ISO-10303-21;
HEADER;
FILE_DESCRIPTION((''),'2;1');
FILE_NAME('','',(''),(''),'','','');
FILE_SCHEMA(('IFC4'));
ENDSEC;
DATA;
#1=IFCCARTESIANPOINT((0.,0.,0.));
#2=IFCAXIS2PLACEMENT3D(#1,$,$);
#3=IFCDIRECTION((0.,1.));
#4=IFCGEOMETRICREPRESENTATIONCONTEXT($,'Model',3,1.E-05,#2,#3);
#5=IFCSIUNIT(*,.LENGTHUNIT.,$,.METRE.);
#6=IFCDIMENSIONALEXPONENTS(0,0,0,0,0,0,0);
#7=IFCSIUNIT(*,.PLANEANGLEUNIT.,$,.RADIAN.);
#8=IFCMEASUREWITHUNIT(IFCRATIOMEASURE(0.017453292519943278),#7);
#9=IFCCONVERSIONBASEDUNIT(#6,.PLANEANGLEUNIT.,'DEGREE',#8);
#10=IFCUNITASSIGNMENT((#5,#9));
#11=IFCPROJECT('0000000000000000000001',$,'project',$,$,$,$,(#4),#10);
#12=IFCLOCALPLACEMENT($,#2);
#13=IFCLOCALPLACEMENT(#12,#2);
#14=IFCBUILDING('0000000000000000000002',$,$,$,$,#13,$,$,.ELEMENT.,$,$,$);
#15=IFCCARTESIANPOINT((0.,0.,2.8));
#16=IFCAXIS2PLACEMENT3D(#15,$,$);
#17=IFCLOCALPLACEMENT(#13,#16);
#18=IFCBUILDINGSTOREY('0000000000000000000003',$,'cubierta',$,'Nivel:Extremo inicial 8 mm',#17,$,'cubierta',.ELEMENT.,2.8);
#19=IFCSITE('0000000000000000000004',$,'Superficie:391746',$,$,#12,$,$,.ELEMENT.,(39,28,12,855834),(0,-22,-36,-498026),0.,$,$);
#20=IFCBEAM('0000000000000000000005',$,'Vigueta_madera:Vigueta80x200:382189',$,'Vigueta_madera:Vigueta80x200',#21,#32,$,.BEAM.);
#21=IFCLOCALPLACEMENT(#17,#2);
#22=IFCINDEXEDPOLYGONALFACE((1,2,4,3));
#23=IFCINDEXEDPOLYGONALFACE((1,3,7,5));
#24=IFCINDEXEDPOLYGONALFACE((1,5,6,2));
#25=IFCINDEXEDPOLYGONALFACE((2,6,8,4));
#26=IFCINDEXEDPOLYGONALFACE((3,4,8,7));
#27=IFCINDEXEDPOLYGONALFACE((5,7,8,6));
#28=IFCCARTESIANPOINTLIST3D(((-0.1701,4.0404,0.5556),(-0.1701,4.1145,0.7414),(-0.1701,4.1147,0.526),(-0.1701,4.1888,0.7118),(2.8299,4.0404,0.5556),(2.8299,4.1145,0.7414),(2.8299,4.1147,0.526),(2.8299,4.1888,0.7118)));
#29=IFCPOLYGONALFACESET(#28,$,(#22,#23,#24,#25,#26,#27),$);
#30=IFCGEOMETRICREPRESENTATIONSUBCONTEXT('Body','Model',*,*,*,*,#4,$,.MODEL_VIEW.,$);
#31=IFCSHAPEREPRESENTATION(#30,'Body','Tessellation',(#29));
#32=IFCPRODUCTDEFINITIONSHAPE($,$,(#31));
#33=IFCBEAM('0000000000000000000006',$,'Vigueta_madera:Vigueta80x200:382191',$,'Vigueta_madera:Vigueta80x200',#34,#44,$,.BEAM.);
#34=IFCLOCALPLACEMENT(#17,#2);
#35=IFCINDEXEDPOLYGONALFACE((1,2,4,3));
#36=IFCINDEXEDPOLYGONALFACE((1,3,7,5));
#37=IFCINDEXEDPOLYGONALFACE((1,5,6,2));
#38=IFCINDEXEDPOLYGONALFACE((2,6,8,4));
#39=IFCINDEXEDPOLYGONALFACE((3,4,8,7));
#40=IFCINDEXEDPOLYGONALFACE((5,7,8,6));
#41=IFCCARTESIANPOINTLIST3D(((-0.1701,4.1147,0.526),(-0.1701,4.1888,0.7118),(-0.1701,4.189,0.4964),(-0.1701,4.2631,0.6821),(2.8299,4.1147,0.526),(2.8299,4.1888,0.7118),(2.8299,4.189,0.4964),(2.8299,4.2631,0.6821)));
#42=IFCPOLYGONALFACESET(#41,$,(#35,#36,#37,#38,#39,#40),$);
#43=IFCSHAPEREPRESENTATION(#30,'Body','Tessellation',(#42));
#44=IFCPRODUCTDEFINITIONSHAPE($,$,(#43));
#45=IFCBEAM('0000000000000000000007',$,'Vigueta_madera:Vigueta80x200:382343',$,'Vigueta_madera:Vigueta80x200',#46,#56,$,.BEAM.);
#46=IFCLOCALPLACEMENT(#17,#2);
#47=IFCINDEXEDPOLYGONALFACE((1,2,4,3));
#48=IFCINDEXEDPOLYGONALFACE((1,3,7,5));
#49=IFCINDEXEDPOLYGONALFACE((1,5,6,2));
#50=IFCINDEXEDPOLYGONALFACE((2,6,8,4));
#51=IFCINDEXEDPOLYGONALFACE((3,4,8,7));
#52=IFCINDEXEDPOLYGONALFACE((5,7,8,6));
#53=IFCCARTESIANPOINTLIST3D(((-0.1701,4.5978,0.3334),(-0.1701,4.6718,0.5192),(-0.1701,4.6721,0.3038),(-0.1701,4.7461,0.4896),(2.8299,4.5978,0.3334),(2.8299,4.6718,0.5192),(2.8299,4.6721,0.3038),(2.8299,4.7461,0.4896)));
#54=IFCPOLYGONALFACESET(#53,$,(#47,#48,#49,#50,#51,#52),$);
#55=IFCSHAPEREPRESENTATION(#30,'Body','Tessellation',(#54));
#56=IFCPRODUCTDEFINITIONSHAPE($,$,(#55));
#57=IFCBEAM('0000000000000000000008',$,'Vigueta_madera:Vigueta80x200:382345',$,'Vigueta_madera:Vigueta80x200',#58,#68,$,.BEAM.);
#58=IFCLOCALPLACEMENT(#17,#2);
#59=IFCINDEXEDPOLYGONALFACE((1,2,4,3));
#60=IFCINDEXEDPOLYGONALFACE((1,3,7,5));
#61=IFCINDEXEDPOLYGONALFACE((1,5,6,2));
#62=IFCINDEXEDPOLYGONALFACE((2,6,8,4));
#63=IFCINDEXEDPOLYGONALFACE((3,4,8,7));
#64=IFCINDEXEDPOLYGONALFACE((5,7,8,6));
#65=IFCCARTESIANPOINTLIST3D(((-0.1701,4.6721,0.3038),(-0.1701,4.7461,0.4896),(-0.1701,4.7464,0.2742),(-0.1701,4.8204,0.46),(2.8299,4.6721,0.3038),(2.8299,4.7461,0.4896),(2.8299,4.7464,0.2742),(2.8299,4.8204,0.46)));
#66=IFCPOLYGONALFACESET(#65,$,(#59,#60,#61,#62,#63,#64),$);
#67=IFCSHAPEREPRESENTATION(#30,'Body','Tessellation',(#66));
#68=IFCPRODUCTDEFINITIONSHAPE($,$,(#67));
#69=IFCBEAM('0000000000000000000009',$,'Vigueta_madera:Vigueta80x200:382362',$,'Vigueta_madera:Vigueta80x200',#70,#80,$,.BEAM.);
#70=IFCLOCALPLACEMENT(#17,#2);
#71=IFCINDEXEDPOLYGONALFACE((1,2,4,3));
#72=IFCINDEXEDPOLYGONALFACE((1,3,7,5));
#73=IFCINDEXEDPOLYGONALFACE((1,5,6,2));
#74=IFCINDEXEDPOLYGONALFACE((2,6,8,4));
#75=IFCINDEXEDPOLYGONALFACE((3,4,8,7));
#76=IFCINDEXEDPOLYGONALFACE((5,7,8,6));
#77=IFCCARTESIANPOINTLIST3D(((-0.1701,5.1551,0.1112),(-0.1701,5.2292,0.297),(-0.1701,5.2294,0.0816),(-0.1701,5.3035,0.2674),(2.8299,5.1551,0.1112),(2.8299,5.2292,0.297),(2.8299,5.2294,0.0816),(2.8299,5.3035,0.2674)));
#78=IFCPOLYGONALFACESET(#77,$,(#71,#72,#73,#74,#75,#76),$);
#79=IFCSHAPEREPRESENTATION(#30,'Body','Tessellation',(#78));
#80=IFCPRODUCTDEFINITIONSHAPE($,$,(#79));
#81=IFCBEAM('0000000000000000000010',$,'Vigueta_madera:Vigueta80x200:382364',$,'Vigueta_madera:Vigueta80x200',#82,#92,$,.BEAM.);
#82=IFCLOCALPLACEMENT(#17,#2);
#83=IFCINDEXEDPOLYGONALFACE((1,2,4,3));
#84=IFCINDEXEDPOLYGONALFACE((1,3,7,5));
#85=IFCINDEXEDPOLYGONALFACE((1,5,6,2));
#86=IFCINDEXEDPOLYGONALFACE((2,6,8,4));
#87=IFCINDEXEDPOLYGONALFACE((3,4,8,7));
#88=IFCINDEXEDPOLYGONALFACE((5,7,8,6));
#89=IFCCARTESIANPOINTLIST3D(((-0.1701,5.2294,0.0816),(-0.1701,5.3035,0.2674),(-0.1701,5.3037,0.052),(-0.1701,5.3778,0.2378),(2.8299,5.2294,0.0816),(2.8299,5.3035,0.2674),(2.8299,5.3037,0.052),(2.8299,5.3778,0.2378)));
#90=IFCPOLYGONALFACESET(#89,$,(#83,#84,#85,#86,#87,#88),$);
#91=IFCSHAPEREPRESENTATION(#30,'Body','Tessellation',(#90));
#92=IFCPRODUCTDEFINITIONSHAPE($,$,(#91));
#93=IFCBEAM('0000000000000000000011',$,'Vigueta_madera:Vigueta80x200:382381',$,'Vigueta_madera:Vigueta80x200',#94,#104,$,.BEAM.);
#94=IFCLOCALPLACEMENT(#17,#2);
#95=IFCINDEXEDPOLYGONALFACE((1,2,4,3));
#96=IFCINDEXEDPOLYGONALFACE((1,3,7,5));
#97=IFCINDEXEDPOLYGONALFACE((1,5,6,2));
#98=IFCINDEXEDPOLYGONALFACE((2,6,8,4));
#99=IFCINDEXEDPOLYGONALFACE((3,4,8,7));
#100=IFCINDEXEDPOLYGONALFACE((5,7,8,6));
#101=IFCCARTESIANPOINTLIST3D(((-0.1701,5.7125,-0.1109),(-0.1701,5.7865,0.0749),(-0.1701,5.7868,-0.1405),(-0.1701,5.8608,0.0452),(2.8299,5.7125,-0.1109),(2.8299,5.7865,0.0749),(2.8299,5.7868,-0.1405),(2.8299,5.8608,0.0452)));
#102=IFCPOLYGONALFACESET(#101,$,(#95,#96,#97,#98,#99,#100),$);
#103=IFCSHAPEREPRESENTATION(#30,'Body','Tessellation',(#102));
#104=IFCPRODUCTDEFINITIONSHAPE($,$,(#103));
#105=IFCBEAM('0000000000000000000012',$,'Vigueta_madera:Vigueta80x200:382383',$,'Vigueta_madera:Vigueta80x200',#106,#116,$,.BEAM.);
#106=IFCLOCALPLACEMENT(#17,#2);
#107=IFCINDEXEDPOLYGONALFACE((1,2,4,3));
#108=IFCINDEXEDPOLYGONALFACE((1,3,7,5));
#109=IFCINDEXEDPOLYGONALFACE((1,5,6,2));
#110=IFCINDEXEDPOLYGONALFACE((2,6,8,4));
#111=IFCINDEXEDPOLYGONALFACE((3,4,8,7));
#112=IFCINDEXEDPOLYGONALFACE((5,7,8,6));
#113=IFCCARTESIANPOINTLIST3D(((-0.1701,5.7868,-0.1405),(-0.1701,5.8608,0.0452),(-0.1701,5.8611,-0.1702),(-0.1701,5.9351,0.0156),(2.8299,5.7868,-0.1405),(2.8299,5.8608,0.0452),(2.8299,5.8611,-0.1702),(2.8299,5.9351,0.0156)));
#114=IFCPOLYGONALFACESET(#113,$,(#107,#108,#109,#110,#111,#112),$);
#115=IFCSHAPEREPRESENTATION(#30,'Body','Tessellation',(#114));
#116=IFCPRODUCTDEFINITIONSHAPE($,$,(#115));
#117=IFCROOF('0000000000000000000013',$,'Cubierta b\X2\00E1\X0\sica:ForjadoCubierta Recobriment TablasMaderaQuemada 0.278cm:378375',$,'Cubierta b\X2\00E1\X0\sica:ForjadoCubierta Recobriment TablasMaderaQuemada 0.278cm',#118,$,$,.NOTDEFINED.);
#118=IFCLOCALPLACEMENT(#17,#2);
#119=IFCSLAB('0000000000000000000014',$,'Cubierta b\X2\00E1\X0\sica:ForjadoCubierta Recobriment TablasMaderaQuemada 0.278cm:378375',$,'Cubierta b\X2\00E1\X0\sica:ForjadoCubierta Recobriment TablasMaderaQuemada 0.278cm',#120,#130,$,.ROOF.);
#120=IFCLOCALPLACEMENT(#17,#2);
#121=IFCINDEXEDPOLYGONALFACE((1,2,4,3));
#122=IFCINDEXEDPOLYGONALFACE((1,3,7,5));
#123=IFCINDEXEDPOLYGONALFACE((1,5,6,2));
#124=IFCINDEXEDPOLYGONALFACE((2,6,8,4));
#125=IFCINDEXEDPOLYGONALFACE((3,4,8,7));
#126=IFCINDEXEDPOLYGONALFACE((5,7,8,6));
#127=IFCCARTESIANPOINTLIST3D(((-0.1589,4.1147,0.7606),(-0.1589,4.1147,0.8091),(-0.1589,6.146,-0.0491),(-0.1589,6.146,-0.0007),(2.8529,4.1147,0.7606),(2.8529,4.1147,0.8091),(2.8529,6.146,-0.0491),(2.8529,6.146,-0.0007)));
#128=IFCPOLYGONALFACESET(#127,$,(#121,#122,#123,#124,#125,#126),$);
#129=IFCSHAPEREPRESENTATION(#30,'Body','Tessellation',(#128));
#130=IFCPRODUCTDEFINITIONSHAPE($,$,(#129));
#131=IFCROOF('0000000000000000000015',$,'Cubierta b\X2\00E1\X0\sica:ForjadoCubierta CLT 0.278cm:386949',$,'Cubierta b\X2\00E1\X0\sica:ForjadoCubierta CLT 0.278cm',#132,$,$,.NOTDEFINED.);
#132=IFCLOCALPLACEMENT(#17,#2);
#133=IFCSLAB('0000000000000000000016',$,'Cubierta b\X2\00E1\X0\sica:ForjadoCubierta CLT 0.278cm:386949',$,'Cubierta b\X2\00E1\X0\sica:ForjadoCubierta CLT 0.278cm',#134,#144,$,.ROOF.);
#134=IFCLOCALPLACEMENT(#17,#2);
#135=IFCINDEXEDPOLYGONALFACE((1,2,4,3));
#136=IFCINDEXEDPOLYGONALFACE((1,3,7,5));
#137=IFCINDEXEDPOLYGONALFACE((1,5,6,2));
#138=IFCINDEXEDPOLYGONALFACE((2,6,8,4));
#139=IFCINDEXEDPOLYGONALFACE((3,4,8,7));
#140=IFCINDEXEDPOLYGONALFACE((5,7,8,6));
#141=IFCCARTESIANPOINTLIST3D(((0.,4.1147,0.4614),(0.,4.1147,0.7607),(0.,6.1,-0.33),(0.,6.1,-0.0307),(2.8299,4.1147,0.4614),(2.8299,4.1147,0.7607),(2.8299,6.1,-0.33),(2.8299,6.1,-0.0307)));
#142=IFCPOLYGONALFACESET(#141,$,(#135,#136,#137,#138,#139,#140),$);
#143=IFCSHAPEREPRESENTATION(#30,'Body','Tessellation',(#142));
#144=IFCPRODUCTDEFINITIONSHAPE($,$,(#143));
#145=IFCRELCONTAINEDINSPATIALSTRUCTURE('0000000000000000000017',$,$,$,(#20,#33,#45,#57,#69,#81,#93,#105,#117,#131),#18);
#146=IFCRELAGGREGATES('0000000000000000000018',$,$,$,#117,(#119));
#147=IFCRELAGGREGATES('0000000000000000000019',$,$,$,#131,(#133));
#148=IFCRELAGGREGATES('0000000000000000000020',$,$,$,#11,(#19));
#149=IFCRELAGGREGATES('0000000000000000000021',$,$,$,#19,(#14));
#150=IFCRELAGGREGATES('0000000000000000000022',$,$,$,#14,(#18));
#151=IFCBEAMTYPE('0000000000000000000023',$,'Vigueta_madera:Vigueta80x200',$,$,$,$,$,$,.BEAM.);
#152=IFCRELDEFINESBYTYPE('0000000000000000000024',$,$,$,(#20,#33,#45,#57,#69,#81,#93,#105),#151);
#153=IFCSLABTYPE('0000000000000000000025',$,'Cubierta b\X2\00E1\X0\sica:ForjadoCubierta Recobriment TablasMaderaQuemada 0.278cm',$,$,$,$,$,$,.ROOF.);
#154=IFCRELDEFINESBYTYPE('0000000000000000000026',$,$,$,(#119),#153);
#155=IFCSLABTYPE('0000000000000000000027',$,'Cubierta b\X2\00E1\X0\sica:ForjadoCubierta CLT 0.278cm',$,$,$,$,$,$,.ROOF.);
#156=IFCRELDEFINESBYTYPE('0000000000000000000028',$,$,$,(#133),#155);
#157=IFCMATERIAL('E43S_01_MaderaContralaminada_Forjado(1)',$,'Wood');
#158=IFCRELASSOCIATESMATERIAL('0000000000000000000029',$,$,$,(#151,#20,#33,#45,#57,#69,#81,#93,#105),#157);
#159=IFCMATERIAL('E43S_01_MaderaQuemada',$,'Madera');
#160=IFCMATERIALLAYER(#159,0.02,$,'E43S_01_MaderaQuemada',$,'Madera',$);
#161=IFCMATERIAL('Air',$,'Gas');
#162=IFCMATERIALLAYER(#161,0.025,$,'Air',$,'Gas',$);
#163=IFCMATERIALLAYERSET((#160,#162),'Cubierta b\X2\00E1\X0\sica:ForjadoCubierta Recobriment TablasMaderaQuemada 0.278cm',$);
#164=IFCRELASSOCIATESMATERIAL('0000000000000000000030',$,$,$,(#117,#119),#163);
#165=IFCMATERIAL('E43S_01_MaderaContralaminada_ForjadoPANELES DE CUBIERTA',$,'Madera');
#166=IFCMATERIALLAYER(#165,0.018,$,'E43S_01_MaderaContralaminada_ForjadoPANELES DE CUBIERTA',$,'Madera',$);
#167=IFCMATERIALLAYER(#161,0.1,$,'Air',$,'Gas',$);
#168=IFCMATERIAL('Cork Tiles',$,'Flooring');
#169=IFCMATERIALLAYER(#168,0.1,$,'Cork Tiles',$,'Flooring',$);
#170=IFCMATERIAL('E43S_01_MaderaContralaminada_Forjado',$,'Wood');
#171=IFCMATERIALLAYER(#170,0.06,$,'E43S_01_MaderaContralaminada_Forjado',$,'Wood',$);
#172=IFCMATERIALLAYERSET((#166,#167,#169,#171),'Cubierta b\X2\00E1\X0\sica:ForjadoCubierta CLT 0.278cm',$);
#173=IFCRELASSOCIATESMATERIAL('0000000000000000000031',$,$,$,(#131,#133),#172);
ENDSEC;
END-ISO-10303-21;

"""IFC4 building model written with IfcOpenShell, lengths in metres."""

from ifc_helpers import new_model, entity, si_unit, converted_unit, direction, frame, frame_2d, origin, place, context, subcontext, project, spatial, polyline, segment, composite_curve, rectangle, outline, extrude, source, transform, mapped, material, layer, layer_set, material_profile, profile_set, profile_usage, type_object, type_shapes, element, aggregate, save


model = new_model("IFC4")

# Units and contexts
model_context = context("Model", 3, precision=1e-05, world=origin(), true_north=direction((0.0, 1.0)))
body_context = subcontext(model_context, "Body", "Model", "MODEL_VIEW")
ifc_project = project(units=[si_unit("LENGTHUNIT", "METRE"), converted_unit("PLANEANGLEUNIT", "DEGREE", entity("IfcRatioMeasure", 0.017453292519943278), si_unit("PLANEANGLEUNIT", "RADIAN"), dimensions=[0, 0, 0, 0, 0, 0, 0])], contexts=[model_context])

# Site, building, storey
site_placement = place(None, origin())
site = spatial("IfcSite", under=ifc_project, at=site_placement, Name="Superficie:391746", CompositionType="ELEMENT", RefLatitude=(39, 28, 12, 855834), RefLongitude=(0, -22, -36, -498026), RefElevation=0.0)
building_placement = place(site_placement, origin())
building = spatial("IfcBuilding", under=site, at=building_placement, CompositionType="ELEMENT")
storey_placement = place(building_placement, frame((0.0, 0.0, 2.8)))
storey = spatial("IfcBuildingStorey", under=building, at=storey_placement, Name="cubierta", ObjectType="Nivel:Extremo inicial 8 mm", LongName="cubierta", CompositionType="ELEMENT", Elevation=2.8)

# Beams
ifc_material_1 = material(Name="E43S_01_MaderaContralaminada_Forjado(1)", Category="Wood")
ifc_material_profile_1 = material_profile(ifc_material_1, outline(composite_curve([segment(polyline([(-0.04, -0.1, 0.0), (-0.04, 0.1, 0.0)]), True, "CONTINUOUS"), segment(polyline([(-0.04, 0.1, 0.0), (0.04, 0.1, 0.0)]), True, "CONTINUOUS"), segment(polyline([(0.04, 0.1, 0.0), (0.04, -0.1, 0.0)]), True, "CONTINUOUS"), segment(polyline([(0.04, -0.1, 0.0), (-0.04, -0.1, 0.0)]), True, "CONTINUOUS")], self_intersect=False), kind="CURVE"), Name="Vigueta80x200")
ifc_material_profile_2 = material_profile(ifc_material_1, outline(composite_curve([segment(polyline([(-1.5, -0.04, 0.1), (-1.5, 0.04, 0.1)]), True, "CONTINUOUS"), segment(polyline([(-1.5, 0.04, 0.1), (-1.5, 0.04, -0.1)]), True, "CONTINUOUS"), segment(polyline([(-1.5, 0.04, -0.1), (-1.5, -0.04, -0.1)]), True, "CONTINUOUS"), segment(polyline([(-1.5, -0.04, -0.1), (-1.5, -0.04, 0.1)]), True, "CONTINUOUS")], self_intersect=False), kind="CURVE"), Name="Vigueta80x200")
ifc_profile_set = profile_set([ifc_material_profile_1, ifc_material_profile_2], Name="Vigueta80x200")
ifc_profile_usage_1 = profile_usage(ifc_profile_set, cardinal=8)
beam_type = type_object("IfcBeamType", Name="Vigueta_madera:Vigueta80x200", PredefinedType="BEAM", material=ifc_profile_set)
shared_shape = source(origin(), body_context, "Body", "SweptSolid", [
    extrude(rectangle(XDim=0.2, YDim=0.08, at=frame_2d((0.0, 0.0), x_axis=(1.0, 0.0))), frame((-1.5, 0.0, 0.0), z_axis=(1.0, 0.0, 0.0), x_axis=(0.0, 0.0, -1.0)), (0.0, 0.0, 1.0), 3.0),
])
type_shapes(beam_type, [shared_shape])
beam_1_placement = place(storey_placement, frame((1.3299, 4.1146, 0.6337), z_axis=(0.0, 0.370233, 0.928939), x_axis=(1.0, 0.0, 0.0)))
element("IfcBeam", 1, at=beam_1_placement, inside=storey, type_object=beam_type, material=ifc_profile_usage_1, Name="Vigueta_madera:Vigueta80x200:382189", ObjectType="Vigueta_madera:Vigueta80x200", PredefinedType="BEAM", context=body_context, shape_type="MappedRepresentation", body=[
    mapped(shared_shape, transform((0.0, 0.0, 0.0), scale=1.0)),
])
ifc_profile_usage_2 = profile_usage(ifc_profile_set, cardinal=8)
beam_2_placement = place(storey_placement, frame((1.3299, 4.1889, 0.6041), z_axis=(0.0, 0.370233, 0.928939), x_axis=(1.0, 0.0, 0.0)))
element("IfcBeam", 2, at=beam_2_placement, inside=storey, type_object=beam_type, material=ifc_profile_usage_2, Name="Vigueta_madera:Vigueta80x200:382191", ObjectType="Vigueta_madera:Vigueta80x200", PredefinedType="BEAM", context=body_context, shape_type="MappedRepresentation", body=[
    mapped(shared_shape, transform((0.0, 0.0, 0.0), scale=1.0)),
])
ifc_profile_usage_3 = profile_usage(ifc_profile_set, cardinal=8)
beam_3_placement = place(storey_placement, frame((1.3299, 4.6719, 0.4115), z_axis=(0.0, 0.370233, 0.928939), x_axis=(1.0, 0.0, 0.0)))
element("IfcBeam", 3, at=beam_3_placement, inside=storey, type_object=beam_type, material=ifc_profile_usage_3, Name="Vigueta_madera:Vigueta80x200:382343", ObjectType="Vigueta_madera:Vigueta80x200", PredefinedType="BEAM", context=body_context, shape_type="MappedRepresentation", body=[
    mapped(shared_shape, transform((0.0, 0.0, 0.0), scale=1.0)),
])
ifc_profile_usage_4 = profile_usage(ifc_profile_set, cardinal=8)
beam_4_placement = place(storey_placement, frame((1.3299, 4.7463, 0.3819), z_axis=(0.0, 0.370233, 0.928939), x_axis=(1.0, 0.0, 0.0)))
element("IfcBeam", 4, at=beam_4_placement, inside=storey, type_object=beam_type, material=ifc_profile_usage_4, Name="Vigueta_madera:Vigueta80x200:382345", ObjectType="Vigueta_madera:Vigueta80x200", PredefinedType="BEAM", context=body_context, shape_type="MappedRepresentation", body=[
    mapped(shared_shape, transform((0.0, 0.0, 0.0), scale=1.0)),
])
ifc_profile_usage_5 = profile_usage(ifc_profile_set, cardinal=8)
beam_5_placement = place(storey_placement, frame((1.3299, 5.2293, 0.1893), z_axis=(0.0, 0.370233, 0.928939), x_axis=(1.0, 0.0, 0.0)))
element("IfcBeam", 5, at=beam_5_placement, inside=storey, type_object=beam_type, material=ifc_profile_usage_5, Name="Vigueta_madera:Vigueta80x200:382362", ObjectType="Vigueta_madera:Vigueta80x200", PredefinedType="BEAM", context=body_context, shape_type="MappedRepresentation", body=[
    mapped(shared_shape, transform((0.0, 0.0, 0.0), scale=1.0)),
])
ifc_profile_usage_6 = profile_usage(ifc_profile_set, cardinal=8)
beam_6_placement = place(storey_placement, frame((1.3299, 5.3036, 0.1597), z_axis=(0.0, 0.370233, 0.928939), x_axis=(1.0, 0.0, 0.0)))
element("IfcBeam", 6, at=beam_6_placement, inside=storey, type_object=beam_type, material=ifc_profile_usage_6, Name="Vigueta_madera:Vigueta80x200:382364", ObjectType="Vigueta_madera:Vigueta80x200", PredefinedType="BEAM", context=body_context, shape_type="MappedRepresentation", body=[
    mapped(shared_shape, transform((0.0, 0.0, 0.0), scale=1.0)),
])
ifc_profile_usage_7 = profile_usage(ifc_profile_set, cardinal=8)
beam_7_placement = place(storey_placement, frame((1.3299, 5.7866, -0.0328), z_axis=(0.0, 0.370233, 0.928939), x_axis=(1.0, 0.0, 0.0)))
element("IfcBeam", 7, at=beam_7_placement, inside=storey, type_object=beam_type, material=ifc_profile_usage_7, Name="Vigueta_madera:Vigueta80x200:382381", ObjectType="Vigueta_madera:Vigueta80x200", PredefinedType="BEAM", context=body_context, shape_type="MappedRepresentation", body=[
    mapped(shared_shape, transform((0.0, 0.0, 0.0), scale=1.0)),
])
ifc_profile_usage_8 = profile_usage(ifc_profile_set, cardinal=8)
beam_8_placement = place(storey_placement, frame((1.3299, 5.861, -0.0625), z_axis=(0.0, 0.370233, 0.928939), x_axis=(1.0, 0.0, 0.0)))
element("IfcBeam", 8, at=beam_8_placement, inside=storey, type_object=beam_type, material=ifc_profile_usage_8, Name="Vigueta_madera:Vigueta80x200:382383", ObjectType="Vigueta_madera:Vigueta80x200", PredefinedType="BEAM", context=body_context, shape_type="MappedRepresentation", body=[
    mapped(shared_shape, transform((0.0, 0.0, 0.0), scale=1.0)),
])

# Roofs, slabs
ifc_material_2 = material(Name="E43S_01_MaderaQuemada", Category="Madera")
ifc_layer_1 = layer(ifc_material_2, 0.02, Name="E43S_01_MaderaQuemada", Category="Madera")
ifc_material_3 = material(Name="Air", Category="Gas")
ifc_layer_2 = layer(ifc_material_3, 0.025, Name="Air", Category="Gas")
ifc_layer_set_1 = layer_set([ifc_layer_1, ifc_layer_2], Name="Cubierta básica:ForjadoCubierta Recobriment TablasMaderaQuemada 0.278cm")
roof_1_placement = place(storey_placement, frame((-0.1589, 4.1147, -0.0491)))
roof_1 = element("IfcRoof", 9, at=roof_1_placement, inside=storey, material=ifc_layer_set_1, Name="Cubierta básica:ForjadoCubierta Recobriment TablasMaderaQuemada 0.278cm:378375", ObjectType="Cubierta básica:ForjadoCubierta Recobriment TablasMaderaQuemada 0.278cm", PredefinedType="NOTDEFINED")
slab_type_1 = type_object("IfcSlabType", Name="Cubierta básica:ForjadoCubierta Recobriment TablasMaderaQuemada 0.278cm", PredefinedType="ROOF")
slab_1_placement = place(roof_1_placement, origin())
slab_1 = element("IfcSlab", 10, at=slab_1_placement, type_object=slab_type_1, material=ifc_layer_set_1, Name="Cubierta básica:ForjadoCubierta Recobriment TablasMaderaQuemada 0.278cm:378375", ObjectType="Cubierta básica:ForjadoCubierta Recobriment TablasMaderaQuemada 0.278cm", PredefinedType="ROOF", context=body_context, shape_type="SweptSolid", body=[
    extrude(rectangle(XDim=2.1867, YDim=3.0118, at=frame_2d((0.0, 0.0), x_axis=(0.0, 1.0))), frame((1.5059, 1.0156, 0.4049), z_axis=(0.0, 0.370288, 0.928917), x_axis=(1.0, 0.0, 0.0)), (0.0, -0.370288, 0.928917), 0.0484),
])
aggregate(roof_1, [slab_1])
ifc_material_4 = material(Name="E43S_01_MaderaContralaminada_ForjadoPANELES DE CUBIERTA", Category="Madera")
ifc_layer_3 = layer(ifc_material_4, 0.018, Name="E43S_01_MaderaContralaminada_ForjadoPANELES DE CUBIERTA", Category="Madera")
ifc_layer_4 = layer(ifc_material_3, 0.1, Name="Air", Category="Gas")
ifc_material_5 = material(Name="Cork Tiles", Category="Flooring")
ifc_layer_5 = layer(ifc_material_5, 0.1, Name="Cork Tiles", Category="Flooring")
ifc_material_6 = material(Name="E43S_01_MaderaContralaminada_Forjado", Category="Wood")
ifc_layer_6 = layer(ifc_material_6, 0.06, Name="E43S_01_MaderaContralaminada_Forjado", Category="Wood")
ifc_layer_set_2 = layer_set([ifc_layer_3, ifc_layer_4, ifc_layer_5, ifc_layer_6], Name="Cubierta básica:ForjadoCubierta CLT 0.278cm")
roof_2_placement = place(storey_placement, frame((0.0, 4.1147, -0.33)))
roof_2 = element("IfcRoof", 11, at=roof_2_placement, inside=storey, material=ifc_layer_set_2, Name="Cubierta básica:ForjadoCubierta CLT 0.278cm:386949", ObjectType="Cubierta básica:ForjadoCubierta CLT 0.278cm", PredefinedType="NOTDEFINED")
slab_type_2 = type_object("IfcSlabType", Name="Cubierta básica:ForjadoCubierta CLT 0.278cm", PredefinedType="ROOF")
slab_2_placement = place(roof_2_placement, origin())
slab_2 = element("IfcSlab", 12, at=slab_2_placement, type_object=slab_type_2, material=ifc_layer_set_2, Name="Cubierta básica:ForjadoCubierta CLT 0.278cm:386949", ObjectType="Cubierta básica:ForjadoCubierta CLT 0.278cm", PredefinedType="ROOF", context=body_context, shape_type="SweptSolid", body=[
    extrude(rectangle(XDim=2.1372, YDim=2.8299, at=frame_2d((0.0, 0.0), x_axis=(0.0, 1.0))), frame((1.415, 0.9926, 0.3957), z_axis=(0.0, 0.370288, 0.928917), x_axis=(1.0, 0.0, 0.0)), (0.0, -0.370288, 0.928917), 0.2993),
])
aggregate(roof_2, [slab_2])

save(model, "model.ifc")
